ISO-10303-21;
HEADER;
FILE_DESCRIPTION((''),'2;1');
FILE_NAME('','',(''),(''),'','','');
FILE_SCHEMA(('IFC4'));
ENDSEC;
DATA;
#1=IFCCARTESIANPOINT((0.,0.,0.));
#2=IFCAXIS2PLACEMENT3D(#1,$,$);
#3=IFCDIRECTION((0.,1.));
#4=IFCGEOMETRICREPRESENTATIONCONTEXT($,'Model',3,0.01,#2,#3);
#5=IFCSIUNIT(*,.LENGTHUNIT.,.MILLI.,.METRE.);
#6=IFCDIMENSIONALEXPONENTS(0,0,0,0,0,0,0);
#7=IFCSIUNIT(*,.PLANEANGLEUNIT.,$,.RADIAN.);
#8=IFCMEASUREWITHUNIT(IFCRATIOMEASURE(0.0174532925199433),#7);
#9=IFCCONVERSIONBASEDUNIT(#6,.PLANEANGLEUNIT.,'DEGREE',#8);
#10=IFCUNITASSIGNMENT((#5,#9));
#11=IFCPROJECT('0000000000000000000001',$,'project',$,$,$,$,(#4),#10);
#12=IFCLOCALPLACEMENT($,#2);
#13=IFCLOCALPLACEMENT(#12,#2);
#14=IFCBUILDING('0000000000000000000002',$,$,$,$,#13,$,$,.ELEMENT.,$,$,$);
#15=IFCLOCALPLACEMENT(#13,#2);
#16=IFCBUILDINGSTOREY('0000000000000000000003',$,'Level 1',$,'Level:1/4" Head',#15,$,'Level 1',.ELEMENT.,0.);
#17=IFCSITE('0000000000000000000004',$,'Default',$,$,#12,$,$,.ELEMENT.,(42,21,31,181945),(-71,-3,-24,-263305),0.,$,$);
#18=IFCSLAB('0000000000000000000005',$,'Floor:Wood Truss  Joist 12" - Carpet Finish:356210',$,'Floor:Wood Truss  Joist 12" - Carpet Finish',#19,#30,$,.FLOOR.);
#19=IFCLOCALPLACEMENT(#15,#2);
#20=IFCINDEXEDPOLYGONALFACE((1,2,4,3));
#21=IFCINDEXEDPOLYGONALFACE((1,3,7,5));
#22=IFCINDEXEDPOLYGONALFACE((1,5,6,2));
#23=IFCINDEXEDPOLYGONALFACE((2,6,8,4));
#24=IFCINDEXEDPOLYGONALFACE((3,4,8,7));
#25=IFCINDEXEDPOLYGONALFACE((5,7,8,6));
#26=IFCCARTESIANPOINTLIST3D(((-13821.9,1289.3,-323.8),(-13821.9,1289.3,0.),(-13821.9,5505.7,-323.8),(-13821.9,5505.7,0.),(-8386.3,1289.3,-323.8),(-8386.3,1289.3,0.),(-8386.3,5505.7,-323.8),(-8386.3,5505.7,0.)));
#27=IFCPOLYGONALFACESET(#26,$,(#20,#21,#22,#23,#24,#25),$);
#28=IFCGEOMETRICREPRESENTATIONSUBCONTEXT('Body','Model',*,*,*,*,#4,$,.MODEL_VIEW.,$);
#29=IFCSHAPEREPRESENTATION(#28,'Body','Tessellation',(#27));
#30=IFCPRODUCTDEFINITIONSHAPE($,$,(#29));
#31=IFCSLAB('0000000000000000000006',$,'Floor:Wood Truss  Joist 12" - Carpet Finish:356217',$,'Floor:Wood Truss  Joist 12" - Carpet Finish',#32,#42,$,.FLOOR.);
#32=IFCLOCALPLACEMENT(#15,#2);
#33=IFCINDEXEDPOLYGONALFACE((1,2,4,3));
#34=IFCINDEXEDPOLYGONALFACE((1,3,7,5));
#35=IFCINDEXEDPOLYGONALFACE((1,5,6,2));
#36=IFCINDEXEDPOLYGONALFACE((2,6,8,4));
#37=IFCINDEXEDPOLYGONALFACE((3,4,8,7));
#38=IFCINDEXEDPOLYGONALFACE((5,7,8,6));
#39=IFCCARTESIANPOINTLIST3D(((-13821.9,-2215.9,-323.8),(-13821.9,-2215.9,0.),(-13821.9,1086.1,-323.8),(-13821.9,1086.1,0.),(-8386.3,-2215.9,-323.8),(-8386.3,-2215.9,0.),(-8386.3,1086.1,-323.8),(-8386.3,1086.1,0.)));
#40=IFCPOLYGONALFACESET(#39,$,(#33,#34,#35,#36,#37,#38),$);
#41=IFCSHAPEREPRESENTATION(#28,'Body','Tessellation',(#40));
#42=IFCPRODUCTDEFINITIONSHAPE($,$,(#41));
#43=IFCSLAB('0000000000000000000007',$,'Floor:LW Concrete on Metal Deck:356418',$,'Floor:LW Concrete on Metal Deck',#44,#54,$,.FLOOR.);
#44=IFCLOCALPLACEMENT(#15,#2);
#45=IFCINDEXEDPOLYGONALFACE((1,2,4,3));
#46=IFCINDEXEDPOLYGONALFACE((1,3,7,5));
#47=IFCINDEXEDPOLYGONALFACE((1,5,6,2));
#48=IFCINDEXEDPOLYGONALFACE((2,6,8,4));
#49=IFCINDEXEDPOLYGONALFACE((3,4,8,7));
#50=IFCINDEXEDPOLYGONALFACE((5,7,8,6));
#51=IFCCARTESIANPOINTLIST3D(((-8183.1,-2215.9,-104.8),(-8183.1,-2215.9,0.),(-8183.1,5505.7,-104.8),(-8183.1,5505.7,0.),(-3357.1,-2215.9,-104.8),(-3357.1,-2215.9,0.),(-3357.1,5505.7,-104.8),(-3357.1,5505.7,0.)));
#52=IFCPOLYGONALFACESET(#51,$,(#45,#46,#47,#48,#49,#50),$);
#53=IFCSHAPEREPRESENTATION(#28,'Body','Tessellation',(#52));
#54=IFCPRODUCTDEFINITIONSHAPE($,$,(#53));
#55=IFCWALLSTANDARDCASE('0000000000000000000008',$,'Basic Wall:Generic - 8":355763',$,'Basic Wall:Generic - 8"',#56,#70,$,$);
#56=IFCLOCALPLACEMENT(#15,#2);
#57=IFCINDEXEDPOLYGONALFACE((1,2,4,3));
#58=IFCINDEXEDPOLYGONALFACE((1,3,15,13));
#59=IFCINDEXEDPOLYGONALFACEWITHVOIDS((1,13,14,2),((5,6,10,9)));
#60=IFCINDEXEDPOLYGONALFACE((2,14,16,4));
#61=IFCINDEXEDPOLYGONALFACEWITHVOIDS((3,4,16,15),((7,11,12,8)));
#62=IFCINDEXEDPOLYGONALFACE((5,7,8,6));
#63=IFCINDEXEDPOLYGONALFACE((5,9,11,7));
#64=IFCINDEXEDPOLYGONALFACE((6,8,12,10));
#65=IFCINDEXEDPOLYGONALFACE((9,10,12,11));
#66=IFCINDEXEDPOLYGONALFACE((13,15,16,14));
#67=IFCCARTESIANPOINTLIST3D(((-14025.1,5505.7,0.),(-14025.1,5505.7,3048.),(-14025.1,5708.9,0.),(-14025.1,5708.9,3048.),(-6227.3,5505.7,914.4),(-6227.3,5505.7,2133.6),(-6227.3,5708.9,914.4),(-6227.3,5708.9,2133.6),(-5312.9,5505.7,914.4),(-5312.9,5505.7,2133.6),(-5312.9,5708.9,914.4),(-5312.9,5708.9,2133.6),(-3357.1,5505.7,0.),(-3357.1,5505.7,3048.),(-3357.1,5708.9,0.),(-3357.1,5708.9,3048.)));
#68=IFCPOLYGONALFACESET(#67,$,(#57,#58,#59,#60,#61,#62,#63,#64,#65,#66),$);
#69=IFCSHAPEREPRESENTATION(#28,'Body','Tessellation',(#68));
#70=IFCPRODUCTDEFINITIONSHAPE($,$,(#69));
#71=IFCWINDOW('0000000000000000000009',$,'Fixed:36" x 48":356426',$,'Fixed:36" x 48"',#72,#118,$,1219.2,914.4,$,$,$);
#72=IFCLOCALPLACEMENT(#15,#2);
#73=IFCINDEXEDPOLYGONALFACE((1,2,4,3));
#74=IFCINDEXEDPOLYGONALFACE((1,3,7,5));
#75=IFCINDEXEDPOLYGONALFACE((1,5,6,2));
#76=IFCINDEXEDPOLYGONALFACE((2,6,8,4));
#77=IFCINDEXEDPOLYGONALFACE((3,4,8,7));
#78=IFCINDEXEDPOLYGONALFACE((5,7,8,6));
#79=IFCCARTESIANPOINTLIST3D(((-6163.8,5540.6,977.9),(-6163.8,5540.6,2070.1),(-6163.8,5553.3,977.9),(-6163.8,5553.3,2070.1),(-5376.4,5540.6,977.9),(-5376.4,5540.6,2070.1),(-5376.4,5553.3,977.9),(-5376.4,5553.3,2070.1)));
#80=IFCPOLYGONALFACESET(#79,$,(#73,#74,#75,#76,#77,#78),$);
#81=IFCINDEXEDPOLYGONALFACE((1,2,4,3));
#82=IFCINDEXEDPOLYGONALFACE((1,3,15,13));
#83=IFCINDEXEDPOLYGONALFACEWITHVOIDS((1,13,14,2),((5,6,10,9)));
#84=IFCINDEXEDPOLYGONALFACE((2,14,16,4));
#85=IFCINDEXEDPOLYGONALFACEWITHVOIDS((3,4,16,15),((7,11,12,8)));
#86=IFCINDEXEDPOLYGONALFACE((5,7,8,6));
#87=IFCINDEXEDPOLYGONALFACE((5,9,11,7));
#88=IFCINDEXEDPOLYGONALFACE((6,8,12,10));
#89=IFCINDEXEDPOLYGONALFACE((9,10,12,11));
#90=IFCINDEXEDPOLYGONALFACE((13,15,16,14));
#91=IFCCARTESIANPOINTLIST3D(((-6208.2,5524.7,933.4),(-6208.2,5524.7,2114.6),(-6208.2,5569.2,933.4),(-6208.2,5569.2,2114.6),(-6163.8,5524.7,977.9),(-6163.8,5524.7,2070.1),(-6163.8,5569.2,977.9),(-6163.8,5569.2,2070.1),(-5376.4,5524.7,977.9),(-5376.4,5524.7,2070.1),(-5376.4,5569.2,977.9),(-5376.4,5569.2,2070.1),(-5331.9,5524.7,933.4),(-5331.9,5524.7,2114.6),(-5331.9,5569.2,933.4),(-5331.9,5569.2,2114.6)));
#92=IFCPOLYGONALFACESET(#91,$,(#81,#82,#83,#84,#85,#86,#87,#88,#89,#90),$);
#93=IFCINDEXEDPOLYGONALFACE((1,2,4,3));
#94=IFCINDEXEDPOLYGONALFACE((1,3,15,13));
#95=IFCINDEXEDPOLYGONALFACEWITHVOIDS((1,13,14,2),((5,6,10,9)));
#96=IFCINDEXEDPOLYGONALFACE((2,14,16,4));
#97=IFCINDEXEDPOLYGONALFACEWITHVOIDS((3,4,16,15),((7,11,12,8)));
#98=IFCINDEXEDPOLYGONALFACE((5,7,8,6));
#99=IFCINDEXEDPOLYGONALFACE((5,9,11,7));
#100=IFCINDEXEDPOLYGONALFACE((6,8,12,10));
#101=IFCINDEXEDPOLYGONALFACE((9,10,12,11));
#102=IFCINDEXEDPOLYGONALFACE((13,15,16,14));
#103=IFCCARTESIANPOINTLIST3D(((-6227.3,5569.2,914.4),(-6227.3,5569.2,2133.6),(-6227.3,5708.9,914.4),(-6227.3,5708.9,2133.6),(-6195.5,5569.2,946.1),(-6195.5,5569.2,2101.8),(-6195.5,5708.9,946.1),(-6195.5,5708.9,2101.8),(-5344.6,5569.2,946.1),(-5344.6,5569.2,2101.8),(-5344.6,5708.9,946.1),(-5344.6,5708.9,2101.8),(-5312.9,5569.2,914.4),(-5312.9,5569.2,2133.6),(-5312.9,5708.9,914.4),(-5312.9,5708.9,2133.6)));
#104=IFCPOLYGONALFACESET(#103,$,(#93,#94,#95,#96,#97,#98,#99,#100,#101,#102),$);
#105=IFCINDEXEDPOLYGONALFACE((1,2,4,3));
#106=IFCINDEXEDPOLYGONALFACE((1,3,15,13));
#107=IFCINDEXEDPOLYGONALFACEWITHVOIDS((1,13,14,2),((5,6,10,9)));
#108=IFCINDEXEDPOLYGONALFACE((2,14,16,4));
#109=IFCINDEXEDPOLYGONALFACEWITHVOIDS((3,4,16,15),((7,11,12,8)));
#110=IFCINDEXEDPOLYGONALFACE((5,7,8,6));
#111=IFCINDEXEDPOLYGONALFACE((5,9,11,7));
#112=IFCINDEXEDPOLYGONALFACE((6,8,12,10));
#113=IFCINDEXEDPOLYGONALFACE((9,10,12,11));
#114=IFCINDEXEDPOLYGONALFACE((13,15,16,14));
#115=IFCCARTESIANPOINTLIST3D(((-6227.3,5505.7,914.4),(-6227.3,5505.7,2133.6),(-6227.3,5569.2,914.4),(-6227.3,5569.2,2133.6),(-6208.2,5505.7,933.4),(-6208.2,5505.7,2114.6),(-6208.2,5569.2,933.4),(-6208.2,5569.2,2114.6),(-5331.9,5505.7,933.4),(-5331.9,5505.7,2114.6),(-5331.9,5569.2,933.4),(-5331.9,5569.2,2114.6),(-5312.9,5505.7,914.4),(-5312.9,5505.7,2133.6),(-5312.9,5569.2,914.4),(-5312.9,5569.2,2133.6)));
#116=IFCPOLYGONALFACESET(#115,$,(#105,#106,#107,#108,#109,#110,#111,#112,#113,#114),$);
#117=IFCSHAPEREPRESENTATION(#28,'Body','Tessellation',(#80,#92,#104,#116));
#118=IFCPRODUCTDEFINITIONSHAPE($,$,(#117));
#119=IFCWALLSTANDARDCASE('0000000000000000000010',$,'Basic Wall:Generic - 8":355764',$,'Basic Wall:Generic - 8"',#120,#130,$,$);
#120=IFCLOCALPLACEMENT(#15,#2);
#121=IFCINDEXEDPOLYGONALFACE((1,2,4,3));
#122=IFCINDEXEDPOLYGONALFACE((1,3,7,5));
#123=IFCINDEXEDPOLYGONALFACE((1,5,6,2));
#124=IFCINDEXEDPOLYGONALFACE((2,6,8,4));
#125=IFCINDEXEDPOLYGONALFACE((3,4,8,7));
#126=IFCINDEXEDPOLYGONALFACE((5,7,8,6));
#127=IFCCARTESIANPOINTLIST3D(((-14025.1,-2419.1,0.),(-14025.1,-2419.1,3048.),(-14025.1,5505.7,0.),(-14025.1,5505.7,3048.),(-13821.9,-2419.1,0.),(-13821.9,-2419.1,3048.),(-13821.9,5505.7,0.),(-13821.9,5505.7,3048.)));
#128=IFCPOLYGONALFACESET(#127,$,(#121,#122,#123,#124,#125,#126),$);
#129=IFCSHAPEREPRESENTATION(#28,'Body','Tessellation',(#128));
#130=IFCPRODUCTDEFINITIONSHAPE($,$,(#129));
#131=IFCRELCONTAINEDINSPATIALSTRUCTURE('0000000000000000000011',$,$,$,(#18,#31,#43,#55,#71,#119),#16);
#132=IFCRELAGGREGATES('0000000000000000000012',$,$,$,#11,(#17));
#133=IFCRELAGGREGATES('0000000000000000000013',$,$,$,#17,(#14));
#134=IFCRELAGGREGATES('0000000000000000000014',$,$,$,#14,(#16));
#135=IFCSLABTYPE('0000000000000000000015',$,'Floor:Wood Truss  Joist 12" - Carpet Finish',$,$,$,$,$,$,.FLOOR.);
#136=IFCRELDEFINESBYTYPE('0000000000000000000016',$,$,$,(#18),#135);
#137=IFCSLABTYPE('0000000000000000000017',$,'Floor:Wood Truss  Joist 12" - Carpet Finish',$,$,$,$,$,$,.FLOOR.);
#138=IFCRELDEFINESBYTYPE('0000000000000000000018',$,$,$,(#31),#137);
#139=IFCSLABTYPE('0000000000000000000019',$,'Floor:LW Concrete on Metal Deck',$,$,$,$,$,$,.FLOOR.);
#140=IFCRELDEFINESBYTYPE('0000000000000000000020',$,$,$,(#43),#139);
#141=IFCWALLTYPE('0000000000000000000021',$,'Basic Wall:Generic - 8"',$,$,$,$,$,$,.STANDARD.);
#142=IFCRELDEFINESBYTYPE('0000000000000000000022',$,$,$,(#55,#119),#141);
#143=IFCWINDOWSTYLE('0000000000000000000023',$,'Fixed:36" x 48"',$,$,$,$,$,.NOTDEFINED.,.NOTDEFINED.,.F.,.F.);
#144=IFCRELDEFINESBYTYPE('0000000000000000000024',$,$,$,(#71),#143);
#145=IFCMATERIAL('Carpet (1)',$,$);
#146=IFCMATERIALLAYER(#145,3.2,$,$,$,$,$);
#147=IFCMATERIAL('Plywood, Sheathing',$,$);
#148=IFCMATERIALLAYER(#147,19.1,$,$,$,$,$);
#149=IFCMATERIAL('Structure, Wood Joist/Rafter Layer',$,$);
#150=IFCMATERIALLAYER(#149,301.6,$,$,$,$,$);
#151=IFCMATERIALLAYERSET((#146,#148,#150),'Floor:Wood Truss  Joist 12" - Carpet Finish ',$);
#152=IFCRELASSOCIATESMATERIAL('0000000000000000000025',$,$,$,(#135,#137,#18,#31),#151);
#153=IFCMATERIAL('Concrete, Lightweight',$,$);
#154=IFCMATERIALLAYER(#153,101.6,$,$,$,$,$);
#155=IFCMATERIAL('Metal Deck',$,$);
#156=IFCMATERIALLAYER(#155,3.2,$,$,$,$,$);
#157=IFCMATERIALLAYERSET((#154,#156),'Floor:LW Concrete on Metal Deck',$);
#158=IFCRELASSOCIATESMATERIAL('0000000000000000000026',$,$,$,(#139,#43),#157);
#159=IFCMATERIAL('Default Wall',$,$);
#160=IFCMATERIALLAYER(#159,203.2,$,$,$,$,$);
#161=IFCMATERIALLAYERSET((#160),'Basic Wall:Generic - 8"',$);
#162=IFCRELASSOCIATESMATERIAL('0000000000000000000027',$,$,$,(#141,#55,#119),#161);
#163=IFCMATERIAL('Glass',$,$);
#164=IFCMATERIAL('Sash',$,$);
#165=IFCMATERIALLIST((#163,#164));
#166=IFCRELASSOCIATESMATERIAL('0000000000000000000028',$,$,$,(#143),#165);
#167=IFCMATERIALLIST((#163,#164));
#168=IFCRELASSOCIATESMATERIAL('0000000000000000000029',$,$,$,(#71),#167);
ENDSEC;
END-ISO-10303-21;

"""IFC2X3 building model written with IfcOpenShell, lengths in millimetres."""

from ifc_helpers import new_model, entity, si_unit, converted_unit, direction, frame, frame_2d, origin, place, context, subcontext, project, spatial, polyline, rectangle, outline, extrude, source, transform, mapped, material, material_list, layer, layer_set, layer_usage, type_object, type_shapes, element, fill, save


model = new_model("IFC2X3")

# Units and contexts
model_context = context("Model", 3, precision=0.01, world=origin(), true_north=direction((0.0, 1.0)))
body_context = subcontext(model_context, "Body", "Model", "MODEL_VIEW")
ifc_project = project(units=[si_unit("LENGTHUNIT", "METRE", prefix="MILLI"), converted_unit("PLANEANGLEUNIT", "DEGREE", entity("IfcRatioMeasure", 0.0174532925199433), si_unit("PLANEANGLEUNIT", "RADIAN"), dimensions=[0, 0, 0, 0, 0, 0, 0])], contexts=[model_context])

# Site, building, storey
site_placement = place(None, origin())
site = spatial("IfcSite", under=ifc_project, at=site_placement, Name="Default", CompositionType="ELEMENT", RefLatitude=(42, 21, 31, 181945), RefLongitude=(-71, -3, -24, -263305), RefElevation=0.0)
building_placement = place(site_placement, origin())
building = spatial("IfcBuilding", under=site, at=building_placement, CompositionType="ELEMENT")
storey_placement = place(building_placement, origin())
storey = spatial("IfcBuildingStorey", under=building, at=storey_placement, Name="Level 1", ObjectType="Level:1/4\" Head", LongName="Level 1", CompositionType="ELEMENT", Elevation=0.0)

# Slabs
ifc_material_1 = material(Name="Carpet (1)")
ifc_layer_1 = layer(ifc_material_1, 3.2)
ifc_material_2 = material(Name="Plywood, Sheathing")
ifc_layer_2 = layer(ifc_material_2, 19.1)
ifc_material_3 = material(Name="Structure, Wood Joist/Rafter Layer")
ifc_layer_3 = layer(ifc_material_3, 301.6)
ifc_layer_set_1 = layer_set([ifc_layer_1, ifc_layer_2, ifc_layer_3], Name="Floor:Wood Truss  Joist 12\" - Carpet Finish ")
ifc_layer_usage_1 = layer_usage(ifc_layer_set_1, "AXIS3", "POSITIVE", 0.0)
slab_type_1 = type_object("IfcSlabType", Name="Floor:Wood Truss  Joist 12\" - Carpet Finish", PredefinedType="FLOOR", material=ifc_layer_set_1)
slab_1_placement = place(storey_placement, origin())
element("IfcSlab", 1, at=slab_1_placement, inside=storey, type_object=slab_type_1, material=ifc_layer_usage_1, Name="Floor:Wood Truss  Joist 12\" - Carpet Finish:356210", ObjectType="Floor:Wood Truss  Joist 12\" - Carpet Finish", PredefinedType="FLOOR", context=body_context, shape_type="SweptSolid", body=[
    extrude(rectangle(XDim=4216.4, YDim=5435.6, at=frame_2d((0.0, 0.0), x_axis=(1.0, 0.0))), frame((-11104.1, 3397.5, 0.0), z_axis=(0.0, 0.0, -1.0), x_axis=(0.0, 1.0, 0.0)), (0.0, 0.0, 1.0), 323.9),
])
ifc_layer_usage_2 = layer_usage(ifc_layer_set_1, "AXIS3", "POSITIVE", 0.0)
slab_type_2 = type_object("IfcSlabType", Name="Floor:Wood Truss  Joist 12\" - Carpet Finish", PredefinedType="FLOOR", material=ifc_layer_set_1)
slab_2_placement = place(storey_placement, origin())
element("IfcSlab", 2, at=slab_2_placement, inside=storey, type_object=slab_type_2, material=ifc_layer_usage_2, Name="Floor:Wood Truss  Joist 12\" - Carpet Finish:356217", ObjectType="Floor:Wood Truss  Joist 12\" - Carpet Finish", PredefinedType="FLOOR", context=body_context, shape_type="SweptSolid", body=[
    extrude(rectangle(XDim=3302.0, YDim=5435.6, at=frame_2d((0.0, 0.0), x_axis=(1.0, 0.0))), frame((-11104.1, -564.9, 0.0), z_axis=(0.0, 0.0, -1.0), x_axis=(0.0, 1.0, 0.0)), (0.0, 0.0, 1.0), 323.9),
])
ifc_material_4 = material(Name="Concrete, Lightweight")
ifc_layer_4 = layer(ifc_material_4, 101.6)
ifc_material_5 = material(Name="Metal Deck")
ifc_layer_5 = layer(ifc_material_5, 3.2)
ifc_layer_set_2 = layer_set([ifc_layer_4, ifc_layer_5], Name="Floor:LW Concrete on Metal Deck")
ifc_layer_usage_3 = layer_usage(ifc_layer_set_2, "AXIS3", "POSITIVE", 0.0)
slab_type_3 = type_object("IfcSlabType", Name="Floor:LW Concrete on Metal Deck", PredefinedType="FLOOR", material=ifc_layer_set_2)
slab_3_placement = place(storey_placement, origin())
element("IfcSlab", 3, at=slab_3_placement, inside=storey, type_object=slab_type_3, material=ifc_layer_usage_3, Name="Floor:LW Concrete on Metal Deck:356418", ObjectType="Floor:LW Concrete on Metal Deck", PredefinedType="FLOOR", context=body_context, shape_type="SweptSolid", body=[
    extrude(rectangle(XDim=7721.6, YDim=4826.0, at=frame_2d((0.0, 0.0), x_axis=(1.0, 0.0))), frame((-5770.1, 1644.9, 0.0), z_axis=(0.0, 0.0, -1.0), x_axis=(0.0, 1.0, 0.0)), (0.0, 0.0, 1.0), 104.8),
])

# Wall, opening, window
ifc_material_6 = material(Name="Default Wall")
ifc_layer_6 = layer(ifc_material_6, 203.2)
ifc_layer_set_3 = layer_set([ifc_layer_6], Name="Basic Wall:Generic - 8\"")
ifc_layer_usage_4 = layer_usage(ifc_layer_set_3, "AXIS2", "NEGATIVE", 101.6)
wall_type_1 = type_object("IfcWallType", Name="Basic Wall:Generic - 8\"", PredefinedType="STANDARD", material=ifc_layer_set_3)
wall_1_placement = place(storey_placement, frame((-14025.1, 5607.3, 0.0)))
wall_1 = element("IfcWallStandardCase", 4, at=wall_1_placement, inside=storey, type_object=wall_type_1, material=ifc_layer_usage_4, Name="Basic Wall:Generic - 8\":355763", ObjectType="Basic Wall:Generic - 8\"", context=body_context, shape_type="SweptSolid", body=[
    extrude(rectangle(XDim=10668.0, YDim=203.2, at=frame_2d((5334.0, 0.0), x_axis=(-1.0, 0.0))), origin(), (0.0, 0.0, 1.0), 3048.0),
])
opening_1_placement = place(wall_1_placement, frame((8712.2, 101.6, 914.4)))
opening_1 = element("IfcOpeningElement", 5, at=opening_1_placement, cuts=wall_1, ObjectType="Opening", context=body_context, shape_type="SweptSolid", body=[
    extrude(rectangle(XDim=1219.2, YDim=914.4, at=frame_2d((609.6, 457.2), x_axis=(-1.0, 0.0))), frame((0.0, 0.0, 0.0), z_axis=(0.0, -1.0, 0.0), x_axis=(0.0, 0.0, 1.0)), (0.0, 0.0, 1.0), 203.2),
])
ifc_material_7 = material(Name="Glass")
ifc_material_8 = material(Name="Sash")
ifc_material_list_1 = material_list([ifc_material_7, ifc_material_8])
ifc_material_list_2 = material_list([ifc_material_7, ifc_material_8])
window_style = type_object("IfcWindowStyle", Name="Fixed:36\" x 48\"", ConstructionType="NOTDEFINED", OperationType="NOTDEFINED", ParameterTakesPrecedence=False, Sizeable=False, material=ifc_material_list_2)
shared_shape_1 = source(origin(), body_context, "Body", "SweptSolid", [
    extrude(rectangle(XDim=12.7, YDim=787.4, at=frame_2d((0.0, 0.0), x_axis=(1.0, 0.0))), frame((457.2, 161.9, 63.5), z_axis=(0.0, 0.0, 1.0), x_axis=(0.0, 1.0, 0.0)), (0.0, 0.0, 1.0), 1092.2),
    extrude(outline(polyline([(-438.1, -590.6), (438.1, -590.6), (438.1, 590.6), (-438.1, 590.6), (-438.1, -590.6)]), holes=[polyline([(-393.7, -546.1), (-393.7, 546.1), (393.7, 546.1), (393.7, -546.1), (-393.7, -546.1)])]), frame((457.2, 139.7, 609.6), z_axis=(0.0, 1.0, 0.0), x_axis=(1.0, 0.0, 0.0)), (0.0, 0.0, 1.0), 44.5),
    extrude(outline(polyline([(-457.2, -609.6), (457.2, -609.6), (457.2, 609.6), (-457.2, 609.6), (-457.2, -609.6)]), holes=[polyline([(-425.5, -577.8), (-425.5, 577.9), (425.4, 577.9), (425.4, -577.8), (-425.5, -577.8)])]), frame((457.2, 0.0, 609.6), z_axis=(0.0, 1.0, 0.0), x_axis=(1.0, 0.0, 0.0)), (0.0, 0.0, 1.0), 139.7),
    extrude(outline(polyline([(-609.6, -457.2), (609.6, -457.2), (609.6, 457.2), (-609.6, 457.2), (-609.6, -457.2)]), holes=[polyline([(-590.5, -438.1), (-590.5, 438.1), (590.6, 438.1), (590.6, -438.1), (-590.5, -438.1)])]), frame((457.2, 139.7, 609.6), z_axis=(0.0, 1.0, 0.0), x_axis=(0.0, 0.0, -1.0)), (0.0, 0.0, 1.0), 63.5),
])
type_shapes(window_style, [shared_shape_1])
window_placement = place(opening_1_placement, frame((0.0, 0.0, 0.0), z_axis=(0.0, 0.0, 1.0), x_axis=(-1.0, 0.0, 0.0)))
window = element("IfcWindow", 6, at=window_placement, inside=storey, type_object=window_style, material=ifc_material_list_1, Name="Fixed:36\" x 48\":356426", ObjectType="Fixed:36\" x 48\"", OverallHeight=1219.2, OverallWidth=914.4, context=body_context, shape_type="MappedRepresentation", body=[
    mapped(shared_shape_1, transform((0.0, 0.0, 0.0), scale=1.0)),
])
fill(opening_1, window)

# Wall
ifc_layer_usage_5 = layer_usage(ifc_layer_set_3, "AXIS2", "NEGATIVE", 101.6)
wall_2_placement = place(storey_placement, frame((-13923.5, -2419.1, 0.0), z_axis=(0.0, 0.0, 1.0), x_axis=(0.0, 1.0, 0.0)))
element("IfcWallStandardCase", 7, at=wall_2_placement, inside=storey, type_object=wall_type_1, material=ifc_layer_usage_5, Name="Basic Wall:Generic - 8\":355764", ObjectType="Basic Wall:Generic - 8\"", context=body_context, shape_type="SweptSolid", body=[
    extrude(rectangle(XDim=7924.8, YDim=203.2, at=frame_2d((3962.4, 0.0), x_axis=(-1.0, 0.0))), origin(), (0.0, 0.0, 1.0), 3048.0),
])

save(model, "model.ifc")
